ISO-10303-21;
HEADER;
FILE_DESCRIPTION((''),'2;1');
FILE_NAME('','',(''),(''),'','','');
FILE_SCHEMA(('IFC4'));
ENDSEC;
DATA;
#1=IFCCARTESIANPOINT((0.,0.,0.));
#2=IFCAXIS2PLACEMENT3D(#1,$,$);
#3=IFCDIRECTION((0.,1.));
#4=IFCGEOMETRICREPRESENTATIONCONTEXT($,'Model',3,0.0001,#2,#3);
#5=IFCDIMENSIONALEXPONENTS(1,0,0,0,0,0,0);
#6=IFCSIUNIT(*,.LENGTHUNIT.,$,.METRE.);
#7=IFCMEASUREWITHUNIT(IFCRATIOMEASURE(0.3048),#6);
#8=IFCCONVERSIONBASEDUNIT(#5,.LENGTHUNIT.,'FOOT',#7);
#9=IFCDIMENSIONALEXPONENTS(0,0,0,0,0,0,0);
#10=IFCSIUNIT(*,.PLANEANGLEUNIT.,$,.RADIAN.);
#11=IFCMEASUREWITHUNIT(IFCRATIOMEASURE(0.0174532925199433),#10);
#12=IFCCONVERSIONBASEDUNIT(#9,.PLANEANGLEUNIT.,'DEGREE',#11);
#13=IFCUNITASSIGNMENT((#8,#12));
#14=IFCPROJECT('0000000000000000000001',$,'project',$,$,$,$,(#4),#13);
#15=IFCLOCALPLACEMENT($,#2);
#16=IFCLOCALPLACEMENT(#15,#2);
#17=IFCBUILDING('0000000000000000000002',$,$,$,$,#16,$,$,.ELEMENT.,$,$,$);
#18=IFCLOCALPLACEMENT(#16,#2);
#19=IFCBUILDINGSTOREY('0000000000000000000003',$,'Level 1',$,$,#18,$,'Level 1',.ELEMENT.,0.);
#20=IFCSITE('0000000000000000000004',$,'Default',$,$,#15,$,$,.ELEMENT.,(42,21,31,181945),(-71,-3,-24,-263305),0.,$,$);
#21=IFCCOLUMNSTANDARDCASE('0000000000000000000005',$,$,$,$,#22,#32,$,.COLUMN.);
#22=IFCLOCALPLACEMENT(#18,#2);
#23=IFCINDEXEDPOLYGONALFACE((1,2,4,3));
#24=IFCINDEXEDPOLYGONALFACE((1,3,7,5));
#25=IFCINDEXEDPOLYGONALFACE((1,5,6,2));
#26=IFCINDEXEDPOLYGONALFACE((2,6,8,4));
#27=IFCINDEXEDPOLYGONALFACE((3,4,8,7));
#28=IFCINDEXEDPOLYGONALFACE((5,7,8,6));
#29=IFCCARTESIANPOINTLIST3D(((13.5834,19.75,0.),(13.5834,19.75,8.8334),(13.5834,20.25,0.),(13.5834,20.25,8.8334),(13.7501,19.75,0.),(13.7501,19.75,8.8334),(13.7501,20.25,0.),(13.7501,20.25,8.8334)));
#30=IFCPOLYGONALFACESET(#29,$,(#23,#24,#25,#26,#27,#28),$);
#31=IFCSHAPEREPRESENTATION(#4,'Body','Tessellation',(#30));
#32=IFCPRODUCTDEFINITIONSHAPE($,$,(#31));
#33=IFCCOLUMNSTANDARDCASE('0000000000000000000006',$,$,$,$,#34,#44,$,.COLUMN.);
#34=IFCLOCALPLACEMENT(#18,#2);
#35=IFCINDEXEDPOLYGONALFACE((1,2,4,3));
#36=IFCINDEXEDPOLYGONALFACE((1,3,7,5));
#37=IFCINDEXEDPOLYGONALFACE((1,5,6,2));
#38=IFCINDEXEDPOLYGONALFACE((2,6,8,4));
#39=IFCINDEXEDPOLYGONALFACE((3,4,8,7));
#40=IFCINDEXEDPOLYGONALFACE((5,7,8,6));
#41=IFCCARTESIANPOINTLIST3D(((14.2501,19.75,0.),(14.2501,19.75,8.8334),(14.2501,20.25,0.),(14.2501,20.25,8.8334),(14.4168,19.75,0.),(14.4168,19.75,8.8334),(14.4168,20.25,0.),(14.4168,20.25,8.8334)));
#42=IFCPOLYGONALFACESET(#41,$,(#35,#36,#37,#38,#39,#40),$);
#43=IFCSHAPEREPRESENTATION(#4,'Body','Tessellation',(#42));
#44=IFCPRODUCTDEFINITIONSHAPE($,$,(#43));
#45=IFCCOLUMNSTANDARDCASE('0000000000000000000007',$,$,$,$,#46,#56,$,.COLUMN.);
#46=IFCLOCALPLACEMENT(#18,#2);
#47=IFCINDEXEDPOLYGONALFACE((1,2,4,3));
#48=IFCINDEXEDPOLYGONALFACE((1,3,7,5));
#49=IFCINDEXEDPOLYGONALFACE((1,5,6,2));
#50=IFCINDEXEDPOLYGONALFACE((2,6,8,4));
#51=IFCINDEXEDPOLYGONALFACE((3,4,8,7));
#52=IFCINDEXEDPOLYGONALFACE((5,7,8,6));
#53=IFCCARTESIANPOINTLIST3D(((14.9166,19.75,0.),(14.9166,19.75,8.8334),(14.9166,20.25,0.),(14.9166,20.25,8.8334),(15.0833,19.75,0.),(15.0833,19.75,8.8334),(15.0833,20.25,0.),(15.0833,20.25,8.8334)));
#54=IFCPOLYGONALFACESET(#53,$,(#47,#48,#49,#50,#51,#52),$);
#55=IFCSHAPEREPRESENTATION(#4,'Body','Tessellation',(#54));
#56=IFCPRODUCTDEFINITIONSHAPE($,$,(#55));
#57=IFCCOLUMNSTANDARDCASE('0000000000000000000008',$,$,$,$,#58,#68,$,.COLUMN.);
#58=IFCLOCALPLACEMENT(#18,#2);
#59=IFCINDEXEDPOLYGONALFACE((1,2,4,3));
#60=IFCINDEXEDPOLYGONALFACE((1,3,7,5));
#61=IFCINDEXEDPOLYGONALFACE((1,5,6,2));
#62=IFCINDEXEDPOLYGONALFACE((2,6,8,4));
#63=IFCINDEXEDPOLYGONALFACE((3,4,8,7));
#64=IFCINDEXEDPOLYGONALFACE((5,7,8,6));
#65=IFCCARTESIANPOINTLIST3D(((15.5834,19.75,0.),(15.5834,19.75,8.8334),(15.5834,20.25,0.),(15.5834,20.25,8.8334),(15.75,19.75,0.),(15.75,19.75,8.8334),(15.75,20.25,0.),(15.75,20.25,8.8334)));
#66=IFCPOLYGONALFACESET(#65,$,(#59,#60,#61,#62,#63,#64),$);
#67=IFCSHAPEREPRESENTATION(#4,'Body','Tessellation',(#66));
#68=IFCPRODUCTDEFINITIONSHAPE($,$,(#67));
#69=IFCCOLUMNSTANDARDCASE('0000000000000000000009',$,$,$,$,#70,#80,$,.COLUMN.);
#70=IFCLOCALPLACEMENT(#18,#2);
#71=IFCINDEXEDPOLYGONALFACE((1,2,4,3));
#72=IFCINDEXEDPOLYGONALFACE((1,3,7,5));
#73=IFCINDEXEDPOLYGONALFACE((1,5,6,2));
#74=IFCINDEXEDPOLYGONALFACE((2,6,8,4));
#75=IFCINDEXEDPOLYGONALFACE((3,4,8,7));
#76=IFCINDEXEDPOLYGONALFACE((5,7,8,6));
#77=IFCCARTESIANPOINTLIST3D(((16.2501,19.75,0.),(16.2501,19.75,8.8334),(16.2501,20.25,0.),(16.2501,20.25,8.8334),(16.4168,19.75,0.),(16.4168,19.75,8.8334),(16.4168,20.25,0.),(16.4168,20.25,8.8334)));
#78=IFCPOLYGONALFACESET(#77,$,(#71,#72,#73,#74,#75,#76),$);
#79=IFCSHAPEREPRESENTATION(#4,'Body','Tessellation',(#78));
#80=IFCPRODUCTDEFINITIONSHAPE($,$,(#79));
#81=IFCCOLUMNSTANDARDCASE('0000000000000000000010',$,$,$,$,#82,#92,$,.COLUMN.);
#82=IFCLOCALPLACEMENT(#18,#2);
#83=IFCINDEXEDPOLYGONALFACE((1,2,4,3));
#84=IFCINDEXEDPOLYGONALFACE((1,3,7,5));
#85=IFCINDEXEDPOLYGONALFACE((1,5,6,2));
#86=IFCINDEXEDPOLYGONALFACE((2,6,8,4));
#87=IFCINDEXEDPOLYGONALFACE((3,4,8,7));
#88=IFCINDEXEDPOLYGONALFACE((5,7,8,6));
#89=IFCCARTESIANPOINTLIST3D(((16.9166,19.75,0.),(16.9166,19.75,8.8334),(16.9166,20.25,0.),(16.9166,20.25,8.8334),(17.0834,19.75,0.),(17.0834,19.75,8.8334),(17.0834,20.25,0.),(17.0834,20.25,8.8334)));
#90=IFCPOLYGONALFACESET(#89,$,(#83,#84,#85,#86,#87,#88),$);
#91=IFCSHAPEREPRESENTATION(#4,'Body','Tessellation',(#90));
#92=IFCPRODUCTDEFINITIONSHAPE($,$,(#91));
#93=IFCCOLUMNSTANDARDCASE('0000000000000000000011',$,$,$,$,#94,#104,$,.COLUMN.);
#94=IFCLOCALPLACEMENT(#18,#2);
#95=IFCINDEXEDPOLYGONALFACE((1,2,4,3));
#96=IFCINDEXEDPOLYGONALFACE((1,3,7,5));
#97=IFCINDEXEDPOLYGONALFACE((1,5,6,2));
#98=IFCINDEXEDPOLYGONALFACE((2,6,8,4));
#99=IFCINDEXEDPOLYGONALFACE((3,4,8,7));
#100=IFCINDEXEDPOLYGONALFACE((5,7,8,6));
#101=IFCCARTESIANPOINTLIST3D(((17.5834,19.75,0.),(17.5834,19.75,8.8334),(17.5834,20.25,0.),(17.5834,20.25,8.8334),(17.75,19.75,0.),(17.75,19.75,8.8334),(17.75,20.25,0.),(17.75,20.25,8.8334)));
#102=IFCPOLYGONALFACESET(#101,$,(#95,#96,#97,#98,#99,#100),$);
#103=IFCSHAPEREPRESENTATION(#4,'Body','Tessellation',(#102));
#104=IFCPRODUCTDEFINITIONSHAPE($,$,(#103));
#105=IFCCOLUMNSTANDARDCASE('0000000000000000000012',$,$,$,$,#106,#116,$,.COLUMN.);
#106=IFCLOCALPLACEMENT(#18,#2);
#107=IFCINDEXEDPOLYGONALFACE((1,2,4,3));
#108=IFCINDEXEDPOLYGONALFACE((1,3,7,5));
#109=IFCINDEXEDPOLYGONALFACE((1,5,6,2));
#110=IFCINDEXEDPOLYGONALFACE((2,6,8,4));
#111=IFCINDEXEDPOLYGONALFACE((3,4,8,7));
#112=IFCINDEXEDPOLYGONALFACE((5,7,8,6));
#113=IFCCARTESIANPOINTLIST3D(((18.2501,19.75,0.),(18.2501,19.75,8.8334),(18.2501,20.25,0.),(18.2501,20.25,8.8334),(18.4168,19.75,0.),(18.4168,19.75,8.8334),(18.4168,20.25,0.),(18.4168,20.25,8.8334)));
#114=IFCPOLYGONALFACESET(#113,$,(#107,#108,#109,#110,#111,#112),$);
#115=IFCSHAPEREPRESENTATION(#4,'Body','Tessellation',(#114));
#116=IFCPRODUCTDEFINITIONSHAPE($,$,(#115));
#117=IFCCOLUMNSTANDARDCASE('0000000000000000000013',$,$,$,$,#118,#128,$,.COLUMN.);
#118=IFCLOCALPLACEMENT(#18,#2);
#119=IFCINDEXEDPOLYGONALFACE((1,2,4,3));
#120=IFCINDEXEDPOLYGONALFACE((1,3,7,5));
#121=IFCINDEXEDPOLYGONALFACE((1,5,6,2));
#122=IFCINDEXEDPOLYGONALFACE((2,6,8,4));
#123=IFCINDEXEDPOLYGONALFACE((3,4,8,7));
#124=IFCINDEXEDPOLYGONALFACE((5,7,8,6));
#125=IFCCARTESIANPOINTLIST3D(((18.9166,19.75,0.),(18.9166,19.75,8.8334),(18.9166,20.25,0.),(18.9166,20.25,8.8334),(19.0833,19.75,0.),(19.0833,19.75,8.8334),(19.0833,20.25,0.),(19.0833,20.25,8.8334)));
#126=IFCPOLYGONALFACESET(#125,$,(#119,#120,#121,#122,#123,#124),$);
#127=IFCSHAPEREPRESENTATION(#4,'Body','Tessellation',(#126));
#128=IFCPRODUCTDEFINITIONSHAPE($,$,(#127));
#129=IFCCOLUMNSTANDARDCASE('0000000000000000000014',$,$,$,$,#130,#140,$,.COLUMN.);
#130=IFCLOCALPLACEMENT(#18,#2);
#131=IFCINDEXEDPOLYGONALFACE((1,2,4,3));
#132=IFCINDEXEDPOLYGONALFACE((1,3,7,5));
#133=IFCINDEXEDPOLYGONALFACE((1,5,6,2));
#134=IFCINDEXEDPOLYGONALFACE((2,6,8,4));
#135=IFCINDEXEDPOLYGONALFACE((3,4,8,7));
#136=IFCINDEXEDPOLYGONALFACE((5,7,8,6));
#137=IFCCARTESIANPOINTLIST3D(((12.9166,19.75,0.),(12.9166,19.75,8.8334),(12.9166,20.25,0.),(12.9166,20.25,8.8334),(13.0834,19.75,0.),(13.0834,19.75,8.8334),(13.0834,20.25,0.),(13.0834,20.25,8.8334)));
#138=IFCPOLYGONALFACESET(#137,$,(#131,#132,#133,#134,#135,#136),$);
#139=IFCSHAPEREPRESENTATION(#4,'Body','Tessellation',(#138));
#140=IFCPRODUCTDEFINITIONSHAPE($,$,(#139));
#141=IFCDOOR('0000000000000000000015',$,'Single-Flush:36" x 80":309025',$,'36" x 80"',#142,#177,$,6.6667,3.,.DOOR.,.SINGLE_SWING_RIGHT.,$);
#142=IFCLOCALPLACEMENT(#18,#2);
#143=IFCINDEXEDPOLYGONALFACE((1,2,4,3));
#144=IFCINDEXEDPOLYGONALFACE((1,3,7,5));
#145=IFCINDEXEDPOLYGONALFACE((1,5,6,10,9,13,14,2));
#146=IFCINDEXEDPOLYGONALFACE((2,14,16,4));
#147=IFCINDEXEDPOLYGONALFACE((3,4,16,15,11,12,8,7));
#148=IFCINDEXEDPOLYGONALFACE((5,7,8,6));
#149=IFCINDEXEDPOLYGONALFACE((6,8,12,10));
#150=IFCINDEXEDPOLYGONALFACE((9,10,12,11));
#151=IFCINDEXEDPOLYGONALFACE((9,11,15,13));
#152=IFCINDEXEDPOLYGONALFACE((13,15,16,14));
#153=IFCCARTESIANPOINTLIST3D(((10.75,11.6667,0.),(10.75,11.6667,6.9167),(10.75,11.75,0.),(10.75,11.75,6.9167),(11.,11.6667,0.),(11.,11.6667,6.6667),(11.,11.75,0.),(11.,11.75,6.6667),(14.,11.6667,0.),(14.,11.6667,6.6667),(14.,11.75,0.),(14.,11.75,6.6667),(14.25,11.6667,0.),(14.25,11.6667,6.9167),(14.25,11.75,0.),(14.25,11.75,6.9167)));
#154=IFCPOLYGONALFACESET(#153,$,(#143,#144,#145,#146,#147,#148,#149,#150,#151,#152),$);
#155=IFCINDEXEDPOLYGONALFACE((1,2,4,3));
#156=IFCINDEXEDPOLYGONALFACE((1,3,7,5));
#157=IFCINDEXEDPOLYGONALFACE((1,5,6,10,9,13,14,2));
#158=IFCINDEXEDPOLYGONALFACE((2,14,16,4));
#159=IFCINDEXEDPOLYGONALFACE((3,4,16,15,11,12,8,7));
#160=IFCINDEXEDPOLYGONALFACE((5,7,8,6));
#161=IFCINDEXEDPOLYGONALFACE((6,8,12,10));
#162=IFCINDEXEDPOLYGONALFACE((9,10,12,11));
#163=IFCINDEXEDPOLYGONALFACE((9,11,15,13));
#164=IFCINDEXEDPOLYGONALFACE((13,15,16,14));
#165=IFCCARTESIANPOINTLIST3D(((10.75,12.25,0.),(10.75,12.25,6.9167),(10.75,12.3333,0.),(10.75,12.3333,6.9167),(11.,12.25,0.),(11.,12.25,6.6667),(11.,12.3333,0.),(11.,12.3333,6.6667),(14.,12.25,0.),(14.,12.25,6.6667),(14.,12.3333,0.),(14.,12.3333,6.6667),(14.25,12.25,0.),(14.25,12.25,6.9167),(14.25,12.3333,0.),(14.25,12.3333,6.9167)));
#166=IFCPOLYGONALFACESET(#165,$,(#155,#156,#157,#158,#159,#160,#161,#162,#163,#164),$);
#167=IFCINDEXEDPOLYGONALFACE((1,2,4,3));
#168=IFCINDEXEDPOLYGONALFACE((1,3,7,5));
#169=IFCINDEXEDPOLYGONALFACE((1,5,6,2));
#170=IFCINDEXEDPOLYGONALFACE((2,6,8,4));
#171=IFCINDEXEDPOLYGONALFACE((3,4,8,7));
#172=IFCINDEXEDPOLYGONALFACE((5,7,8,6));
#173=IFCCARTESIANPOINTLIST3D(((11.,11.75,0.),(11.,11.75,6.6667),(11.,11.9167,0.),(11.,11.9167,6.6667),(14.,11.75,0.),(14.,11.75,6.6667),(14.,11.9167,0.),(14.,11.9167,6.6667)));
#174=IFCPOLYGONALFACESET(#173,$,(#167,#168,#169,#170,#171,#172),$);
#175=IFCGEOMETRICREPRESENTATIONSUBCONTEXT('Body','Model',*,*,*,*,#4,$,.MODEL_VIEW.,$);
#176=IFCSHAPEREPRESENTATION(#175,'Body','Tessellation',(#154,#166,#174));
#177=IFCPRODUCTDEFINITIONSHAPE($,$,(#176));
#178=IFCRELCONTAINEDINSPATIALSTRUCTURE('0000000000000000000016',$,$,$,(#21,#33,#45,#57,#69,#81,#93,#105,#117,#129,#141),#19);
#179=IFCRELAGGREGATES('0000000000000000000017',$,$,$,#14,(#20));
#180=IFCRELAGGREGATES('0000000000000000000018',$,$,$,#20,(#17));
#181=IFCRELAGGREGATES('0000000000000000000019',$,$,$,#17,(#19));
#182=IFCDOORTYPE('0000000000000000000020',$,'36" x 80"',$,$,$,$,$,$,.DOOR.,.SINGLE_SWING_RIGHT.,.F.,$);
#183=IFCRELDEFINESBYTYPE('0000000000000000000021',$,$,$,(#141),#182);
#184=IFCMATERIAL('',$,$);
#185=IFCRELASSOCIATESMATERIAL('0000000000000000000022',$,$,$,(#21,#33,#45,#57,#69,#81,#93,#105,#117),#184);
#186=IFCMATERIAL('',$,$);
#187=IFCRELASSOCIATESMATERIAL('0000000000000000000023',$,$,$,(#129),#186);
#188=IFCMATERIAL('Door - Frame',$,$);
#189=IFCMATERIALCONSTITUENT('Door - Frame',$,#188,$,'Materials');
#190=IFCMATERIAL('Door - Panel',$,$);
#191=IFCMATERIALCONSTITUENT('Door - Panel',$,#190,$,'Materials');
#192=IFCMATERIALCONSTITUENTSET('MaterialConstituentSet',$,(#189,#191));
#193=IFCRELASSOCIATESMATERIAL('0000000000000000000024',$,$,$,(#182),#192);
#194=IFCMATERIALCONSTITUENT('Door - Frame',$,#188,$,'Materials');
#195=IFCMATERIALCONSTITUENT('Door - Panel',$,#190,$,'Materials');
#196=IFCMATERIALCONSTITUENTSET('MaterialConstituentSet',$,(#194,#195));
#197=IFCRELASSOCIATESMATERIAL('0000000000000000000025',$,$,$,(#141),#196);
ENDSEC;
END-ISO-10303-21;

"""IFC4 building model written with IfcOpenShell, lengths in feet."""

from ifc_helpers import new_model, entity, si_unit, converted_unit, direction, frame, origin, origin_2d_with_axis, place, context, subcontext, project, spatial, polyline, rectangle, outline, extrude, source, transform, mapped, material, constituent, constituent_set, type_object, type_shapes, element, save


model = new_model("IFC4")

# Units and contexts
model_context = context("Model", 3, precision=0.0001, world=origin(), true_north=direction((0.0, 1.0)))
body_context = subcontext(model_context, "Body", "Model", "MODEL_VIEW")
ifc_project = project(units=[converted_unit("LENGTHUNIT", "FOOT", entity("IfcRatioMeasure", 0.3048), si_unit("LENGTHUNIT", "METRE"), dimensions=[1, 0, 0, 0, 0, 0, 0]), converted_unit("PLANEANGLEUNIT", "DEGREE", entity("IfcRatioMeasure", 0.0174532925199433), si_unit("PLANEANGLEUNIT", "RADIAN"), dimensions=[0, 0, 0, 0, 0, 0, 0])], contexts=[model_context])

# Site, building, storey
site_placement = place(None, origin())
site = spatial("IfcSite", under=ifc_project, at=site_placement, Name="Default", CompositionType="ELEMENT", RefLatitude=(42, 21, 31, 181945), RefLongitude=(-71, -3, -24, -263305), RefElevation=0.0)
building_placement = place(site_placement, origin())
building = spatial("IfcBuilding", under=site, at=building_placement, CompositionType="ELEMENT")
storey_placement = place(building_placement, origin())
storey = spatial("IfcBuildingStorey", under=building, at=storey_placement, Name="Level 1", LongName="Level 1", CompositionType="ELEMENT", Elevation=0.0)

# Columns
ifc_material_1 = material(Name="")
placement_1 = place(storey_placement, frame((0.25, 20.0, 0.0)))
for number, where, z_axis, x_axis in (
    (1, (13.4167, 0.0, 0.0), (0.0, 0.0, 1.0), (1.0, 0.0, 0.0)),
    (2, (14.0834, 0.0, 0.0), (0.0, 0.0, 1.0), (1.0, 0.0, 0.0)),
    (3, (14.75, 0.0, 0.0), (0.0, 0.0, 1.0), (1.0, 0.0, 0.0)),
    (4, (15.4167, 0.0, 0.0), (0.0, 0.0, 1.0), (1.0, 0.0, 0.0)),
    (5, (16.0834, 0.0, 0.0), (0.0, 0.0, 1.0), (1.0, 0.0, 0.0)),
    (6, (16.75, 0.0, 0.0), (0.0, 0.0, 1.0), (1.0, 0.0, 0.0)),
    (7, (17.4167, 0.0, 0.0), (0.0, 0.0, 1.0), (1.0, 0.0, 0.0)),
    (8, (18.0834, 0.0, 0.0), (0.0, 0.0, 1.0), (1.0, 0.0, 0.0)),
    (9, (18.75, 0.0, 0.0), (0.0, 0.0, 1.0), (1.0, 0.0, 0.0)),
):
    element("IfcColumnStandardCase", number, at=place(placement_1, frame(where, z_axis=z_axis, x_axis=x_axis)), inside=storey, material=ifc_material_1, PredefinedType="COLUMN", context=model_context, shape_type="SweptSolid", body=[
        extrude(rectangle(XDim=0.1667, YDim=0.5), origin(), (0.0, 0.0, 1.0), 8.8334),
    ])
ifc_material_2 = material(Name="")
for number, where, z_axis, x_axis in (
    (10, (12.75, 0.0, 0.0), (0.0, 0.0, 1.0), (1.0, 0.0, 0.0)),
):
    element("IfcColumnStandardCase", number, at=place(placement_1, frame(where, z_axis=z_axis, x_axis=x_axis)), inside=storey, material=ifc_material_2, PredefinedType="COLUMN", context=model_context, shape_type="SweptSolid", body=[
        extrude(rectangle(XDim=0.1667, YDim=0.5), origin(), (0.0, 0.0, 1.0), 8.8334),
    ])
placement_2 = place(storey_placement, frame((10.25, 12.0, 0.0)))

# Door
ifc_material_3 = material(Name="Door - Frame")
ifc_constituent_1 = constituent(ifc_material_3, Name="Door - Frame", Category="Materials")
ifc_material_4 = material(Name="Door - Panel")
ifc_constituent_2 = constituent(ifc_material_4, Name="Door - Panel", Category="Materials")
ifc_constituent_set_1 = constituent_set(constituents=[ifc_constituent_1, ifc_constituent_2], Name="MaterialConstituentSet")
ifc_constituent_3 = constituent(ifc_material_3, Name="Door - Frame", Category="Materials")
ifc_constituent_4 = constituent(ifc_material_4, Name="Door - Panel", Category="Materials")
ifc_constituent_set_2 = constituent_set(constituents=[ifc_constituent_3, ifc_constituent_4], Name="MaterialConstituentSet")
door_type = type_object("IfcDoorType", Name="36\" x 80\"", OperationType="SINGLE_SWING_RIGHT", ParameterTakesPrecedence=False, PredefinedType="DOOR", material=ifc_constituent_set_2)
shared_shape = source(origin(), body_context, "Body", "SweptSolid", [
    extrude(outline(polyline([(-1.75, -3.5208), (1.75, -3.5208), (1.75, 3.3958), (1.5, 3.3958), (1.5, -3.2708), (-1.5, -3.2708), (-1.5, 3.3958), (-1.75, 3.3958), (-1.75, -3.5208)])), frame((1.5, 0.5, 3.3958), z_axis=(0.0, 1.0, 0.0), x_axis=(1.0, 0.0, 0.0)), (0.0, 0.0, 1.0), 0.0833),
    extrude(outline(polyline([(-3.5208, -1.75), (3.3958, -1.75), (3.3958, -1.5), (-3.2708, -1.5), (-3.2708, 1.5), (3.3958, 1.5), (3.3958, 1.75), (-3.5208, 1.75), (-3.5208, -1.75)])), frame((1.5, -0.0833, 3.3958), z_axis=(0.0, 1.0, 0.0), x_axis=(0.0, 0.0, -1.0)), (0.0, 0.0, 1.0), 0.0833),
    extrude(rectangle(XDim=0.1667, YDim=3.0, at=origin_2d_with_axis()), frame((1.5, 0.4167, 0.0), z_axis=(0.0, 0.0, 1.0), x_axis=(0.0, 1.0, 0.0)), (0.0, 0.0, 1.0), 6.6667),
])
type_shapes(door_type, [shared_shape])
placement_3 = place(placement_2, frame((3.75, 0.25, 0.0)))
door_placement = place(placement_3, frame((0.0, 0.0, 0.0), z_axis=(0.0, 0.0, 1.0), x_axis=(-1.0, 0.0, 0.0)))
element("IfcDoor", 11, at=door_placement, inside=storey, type_object=door_type, material=ifc_constituent_set_1, Name="Single-Flush:36\" x 80\":309025", ObjectType="36\" x 80\"", OperationType="SINGLE_SWING_RIGHT", OverallHeight=6.6667, OverallWidth=3.0, PredefinedType="DOOR", context=body_context, shape_type="MappedRepresentation", body=[
    mapped(shared_shape, transform((0.0, 0.0, 0.0), scale=1.0)),
])

save(model, "model.ifc")
